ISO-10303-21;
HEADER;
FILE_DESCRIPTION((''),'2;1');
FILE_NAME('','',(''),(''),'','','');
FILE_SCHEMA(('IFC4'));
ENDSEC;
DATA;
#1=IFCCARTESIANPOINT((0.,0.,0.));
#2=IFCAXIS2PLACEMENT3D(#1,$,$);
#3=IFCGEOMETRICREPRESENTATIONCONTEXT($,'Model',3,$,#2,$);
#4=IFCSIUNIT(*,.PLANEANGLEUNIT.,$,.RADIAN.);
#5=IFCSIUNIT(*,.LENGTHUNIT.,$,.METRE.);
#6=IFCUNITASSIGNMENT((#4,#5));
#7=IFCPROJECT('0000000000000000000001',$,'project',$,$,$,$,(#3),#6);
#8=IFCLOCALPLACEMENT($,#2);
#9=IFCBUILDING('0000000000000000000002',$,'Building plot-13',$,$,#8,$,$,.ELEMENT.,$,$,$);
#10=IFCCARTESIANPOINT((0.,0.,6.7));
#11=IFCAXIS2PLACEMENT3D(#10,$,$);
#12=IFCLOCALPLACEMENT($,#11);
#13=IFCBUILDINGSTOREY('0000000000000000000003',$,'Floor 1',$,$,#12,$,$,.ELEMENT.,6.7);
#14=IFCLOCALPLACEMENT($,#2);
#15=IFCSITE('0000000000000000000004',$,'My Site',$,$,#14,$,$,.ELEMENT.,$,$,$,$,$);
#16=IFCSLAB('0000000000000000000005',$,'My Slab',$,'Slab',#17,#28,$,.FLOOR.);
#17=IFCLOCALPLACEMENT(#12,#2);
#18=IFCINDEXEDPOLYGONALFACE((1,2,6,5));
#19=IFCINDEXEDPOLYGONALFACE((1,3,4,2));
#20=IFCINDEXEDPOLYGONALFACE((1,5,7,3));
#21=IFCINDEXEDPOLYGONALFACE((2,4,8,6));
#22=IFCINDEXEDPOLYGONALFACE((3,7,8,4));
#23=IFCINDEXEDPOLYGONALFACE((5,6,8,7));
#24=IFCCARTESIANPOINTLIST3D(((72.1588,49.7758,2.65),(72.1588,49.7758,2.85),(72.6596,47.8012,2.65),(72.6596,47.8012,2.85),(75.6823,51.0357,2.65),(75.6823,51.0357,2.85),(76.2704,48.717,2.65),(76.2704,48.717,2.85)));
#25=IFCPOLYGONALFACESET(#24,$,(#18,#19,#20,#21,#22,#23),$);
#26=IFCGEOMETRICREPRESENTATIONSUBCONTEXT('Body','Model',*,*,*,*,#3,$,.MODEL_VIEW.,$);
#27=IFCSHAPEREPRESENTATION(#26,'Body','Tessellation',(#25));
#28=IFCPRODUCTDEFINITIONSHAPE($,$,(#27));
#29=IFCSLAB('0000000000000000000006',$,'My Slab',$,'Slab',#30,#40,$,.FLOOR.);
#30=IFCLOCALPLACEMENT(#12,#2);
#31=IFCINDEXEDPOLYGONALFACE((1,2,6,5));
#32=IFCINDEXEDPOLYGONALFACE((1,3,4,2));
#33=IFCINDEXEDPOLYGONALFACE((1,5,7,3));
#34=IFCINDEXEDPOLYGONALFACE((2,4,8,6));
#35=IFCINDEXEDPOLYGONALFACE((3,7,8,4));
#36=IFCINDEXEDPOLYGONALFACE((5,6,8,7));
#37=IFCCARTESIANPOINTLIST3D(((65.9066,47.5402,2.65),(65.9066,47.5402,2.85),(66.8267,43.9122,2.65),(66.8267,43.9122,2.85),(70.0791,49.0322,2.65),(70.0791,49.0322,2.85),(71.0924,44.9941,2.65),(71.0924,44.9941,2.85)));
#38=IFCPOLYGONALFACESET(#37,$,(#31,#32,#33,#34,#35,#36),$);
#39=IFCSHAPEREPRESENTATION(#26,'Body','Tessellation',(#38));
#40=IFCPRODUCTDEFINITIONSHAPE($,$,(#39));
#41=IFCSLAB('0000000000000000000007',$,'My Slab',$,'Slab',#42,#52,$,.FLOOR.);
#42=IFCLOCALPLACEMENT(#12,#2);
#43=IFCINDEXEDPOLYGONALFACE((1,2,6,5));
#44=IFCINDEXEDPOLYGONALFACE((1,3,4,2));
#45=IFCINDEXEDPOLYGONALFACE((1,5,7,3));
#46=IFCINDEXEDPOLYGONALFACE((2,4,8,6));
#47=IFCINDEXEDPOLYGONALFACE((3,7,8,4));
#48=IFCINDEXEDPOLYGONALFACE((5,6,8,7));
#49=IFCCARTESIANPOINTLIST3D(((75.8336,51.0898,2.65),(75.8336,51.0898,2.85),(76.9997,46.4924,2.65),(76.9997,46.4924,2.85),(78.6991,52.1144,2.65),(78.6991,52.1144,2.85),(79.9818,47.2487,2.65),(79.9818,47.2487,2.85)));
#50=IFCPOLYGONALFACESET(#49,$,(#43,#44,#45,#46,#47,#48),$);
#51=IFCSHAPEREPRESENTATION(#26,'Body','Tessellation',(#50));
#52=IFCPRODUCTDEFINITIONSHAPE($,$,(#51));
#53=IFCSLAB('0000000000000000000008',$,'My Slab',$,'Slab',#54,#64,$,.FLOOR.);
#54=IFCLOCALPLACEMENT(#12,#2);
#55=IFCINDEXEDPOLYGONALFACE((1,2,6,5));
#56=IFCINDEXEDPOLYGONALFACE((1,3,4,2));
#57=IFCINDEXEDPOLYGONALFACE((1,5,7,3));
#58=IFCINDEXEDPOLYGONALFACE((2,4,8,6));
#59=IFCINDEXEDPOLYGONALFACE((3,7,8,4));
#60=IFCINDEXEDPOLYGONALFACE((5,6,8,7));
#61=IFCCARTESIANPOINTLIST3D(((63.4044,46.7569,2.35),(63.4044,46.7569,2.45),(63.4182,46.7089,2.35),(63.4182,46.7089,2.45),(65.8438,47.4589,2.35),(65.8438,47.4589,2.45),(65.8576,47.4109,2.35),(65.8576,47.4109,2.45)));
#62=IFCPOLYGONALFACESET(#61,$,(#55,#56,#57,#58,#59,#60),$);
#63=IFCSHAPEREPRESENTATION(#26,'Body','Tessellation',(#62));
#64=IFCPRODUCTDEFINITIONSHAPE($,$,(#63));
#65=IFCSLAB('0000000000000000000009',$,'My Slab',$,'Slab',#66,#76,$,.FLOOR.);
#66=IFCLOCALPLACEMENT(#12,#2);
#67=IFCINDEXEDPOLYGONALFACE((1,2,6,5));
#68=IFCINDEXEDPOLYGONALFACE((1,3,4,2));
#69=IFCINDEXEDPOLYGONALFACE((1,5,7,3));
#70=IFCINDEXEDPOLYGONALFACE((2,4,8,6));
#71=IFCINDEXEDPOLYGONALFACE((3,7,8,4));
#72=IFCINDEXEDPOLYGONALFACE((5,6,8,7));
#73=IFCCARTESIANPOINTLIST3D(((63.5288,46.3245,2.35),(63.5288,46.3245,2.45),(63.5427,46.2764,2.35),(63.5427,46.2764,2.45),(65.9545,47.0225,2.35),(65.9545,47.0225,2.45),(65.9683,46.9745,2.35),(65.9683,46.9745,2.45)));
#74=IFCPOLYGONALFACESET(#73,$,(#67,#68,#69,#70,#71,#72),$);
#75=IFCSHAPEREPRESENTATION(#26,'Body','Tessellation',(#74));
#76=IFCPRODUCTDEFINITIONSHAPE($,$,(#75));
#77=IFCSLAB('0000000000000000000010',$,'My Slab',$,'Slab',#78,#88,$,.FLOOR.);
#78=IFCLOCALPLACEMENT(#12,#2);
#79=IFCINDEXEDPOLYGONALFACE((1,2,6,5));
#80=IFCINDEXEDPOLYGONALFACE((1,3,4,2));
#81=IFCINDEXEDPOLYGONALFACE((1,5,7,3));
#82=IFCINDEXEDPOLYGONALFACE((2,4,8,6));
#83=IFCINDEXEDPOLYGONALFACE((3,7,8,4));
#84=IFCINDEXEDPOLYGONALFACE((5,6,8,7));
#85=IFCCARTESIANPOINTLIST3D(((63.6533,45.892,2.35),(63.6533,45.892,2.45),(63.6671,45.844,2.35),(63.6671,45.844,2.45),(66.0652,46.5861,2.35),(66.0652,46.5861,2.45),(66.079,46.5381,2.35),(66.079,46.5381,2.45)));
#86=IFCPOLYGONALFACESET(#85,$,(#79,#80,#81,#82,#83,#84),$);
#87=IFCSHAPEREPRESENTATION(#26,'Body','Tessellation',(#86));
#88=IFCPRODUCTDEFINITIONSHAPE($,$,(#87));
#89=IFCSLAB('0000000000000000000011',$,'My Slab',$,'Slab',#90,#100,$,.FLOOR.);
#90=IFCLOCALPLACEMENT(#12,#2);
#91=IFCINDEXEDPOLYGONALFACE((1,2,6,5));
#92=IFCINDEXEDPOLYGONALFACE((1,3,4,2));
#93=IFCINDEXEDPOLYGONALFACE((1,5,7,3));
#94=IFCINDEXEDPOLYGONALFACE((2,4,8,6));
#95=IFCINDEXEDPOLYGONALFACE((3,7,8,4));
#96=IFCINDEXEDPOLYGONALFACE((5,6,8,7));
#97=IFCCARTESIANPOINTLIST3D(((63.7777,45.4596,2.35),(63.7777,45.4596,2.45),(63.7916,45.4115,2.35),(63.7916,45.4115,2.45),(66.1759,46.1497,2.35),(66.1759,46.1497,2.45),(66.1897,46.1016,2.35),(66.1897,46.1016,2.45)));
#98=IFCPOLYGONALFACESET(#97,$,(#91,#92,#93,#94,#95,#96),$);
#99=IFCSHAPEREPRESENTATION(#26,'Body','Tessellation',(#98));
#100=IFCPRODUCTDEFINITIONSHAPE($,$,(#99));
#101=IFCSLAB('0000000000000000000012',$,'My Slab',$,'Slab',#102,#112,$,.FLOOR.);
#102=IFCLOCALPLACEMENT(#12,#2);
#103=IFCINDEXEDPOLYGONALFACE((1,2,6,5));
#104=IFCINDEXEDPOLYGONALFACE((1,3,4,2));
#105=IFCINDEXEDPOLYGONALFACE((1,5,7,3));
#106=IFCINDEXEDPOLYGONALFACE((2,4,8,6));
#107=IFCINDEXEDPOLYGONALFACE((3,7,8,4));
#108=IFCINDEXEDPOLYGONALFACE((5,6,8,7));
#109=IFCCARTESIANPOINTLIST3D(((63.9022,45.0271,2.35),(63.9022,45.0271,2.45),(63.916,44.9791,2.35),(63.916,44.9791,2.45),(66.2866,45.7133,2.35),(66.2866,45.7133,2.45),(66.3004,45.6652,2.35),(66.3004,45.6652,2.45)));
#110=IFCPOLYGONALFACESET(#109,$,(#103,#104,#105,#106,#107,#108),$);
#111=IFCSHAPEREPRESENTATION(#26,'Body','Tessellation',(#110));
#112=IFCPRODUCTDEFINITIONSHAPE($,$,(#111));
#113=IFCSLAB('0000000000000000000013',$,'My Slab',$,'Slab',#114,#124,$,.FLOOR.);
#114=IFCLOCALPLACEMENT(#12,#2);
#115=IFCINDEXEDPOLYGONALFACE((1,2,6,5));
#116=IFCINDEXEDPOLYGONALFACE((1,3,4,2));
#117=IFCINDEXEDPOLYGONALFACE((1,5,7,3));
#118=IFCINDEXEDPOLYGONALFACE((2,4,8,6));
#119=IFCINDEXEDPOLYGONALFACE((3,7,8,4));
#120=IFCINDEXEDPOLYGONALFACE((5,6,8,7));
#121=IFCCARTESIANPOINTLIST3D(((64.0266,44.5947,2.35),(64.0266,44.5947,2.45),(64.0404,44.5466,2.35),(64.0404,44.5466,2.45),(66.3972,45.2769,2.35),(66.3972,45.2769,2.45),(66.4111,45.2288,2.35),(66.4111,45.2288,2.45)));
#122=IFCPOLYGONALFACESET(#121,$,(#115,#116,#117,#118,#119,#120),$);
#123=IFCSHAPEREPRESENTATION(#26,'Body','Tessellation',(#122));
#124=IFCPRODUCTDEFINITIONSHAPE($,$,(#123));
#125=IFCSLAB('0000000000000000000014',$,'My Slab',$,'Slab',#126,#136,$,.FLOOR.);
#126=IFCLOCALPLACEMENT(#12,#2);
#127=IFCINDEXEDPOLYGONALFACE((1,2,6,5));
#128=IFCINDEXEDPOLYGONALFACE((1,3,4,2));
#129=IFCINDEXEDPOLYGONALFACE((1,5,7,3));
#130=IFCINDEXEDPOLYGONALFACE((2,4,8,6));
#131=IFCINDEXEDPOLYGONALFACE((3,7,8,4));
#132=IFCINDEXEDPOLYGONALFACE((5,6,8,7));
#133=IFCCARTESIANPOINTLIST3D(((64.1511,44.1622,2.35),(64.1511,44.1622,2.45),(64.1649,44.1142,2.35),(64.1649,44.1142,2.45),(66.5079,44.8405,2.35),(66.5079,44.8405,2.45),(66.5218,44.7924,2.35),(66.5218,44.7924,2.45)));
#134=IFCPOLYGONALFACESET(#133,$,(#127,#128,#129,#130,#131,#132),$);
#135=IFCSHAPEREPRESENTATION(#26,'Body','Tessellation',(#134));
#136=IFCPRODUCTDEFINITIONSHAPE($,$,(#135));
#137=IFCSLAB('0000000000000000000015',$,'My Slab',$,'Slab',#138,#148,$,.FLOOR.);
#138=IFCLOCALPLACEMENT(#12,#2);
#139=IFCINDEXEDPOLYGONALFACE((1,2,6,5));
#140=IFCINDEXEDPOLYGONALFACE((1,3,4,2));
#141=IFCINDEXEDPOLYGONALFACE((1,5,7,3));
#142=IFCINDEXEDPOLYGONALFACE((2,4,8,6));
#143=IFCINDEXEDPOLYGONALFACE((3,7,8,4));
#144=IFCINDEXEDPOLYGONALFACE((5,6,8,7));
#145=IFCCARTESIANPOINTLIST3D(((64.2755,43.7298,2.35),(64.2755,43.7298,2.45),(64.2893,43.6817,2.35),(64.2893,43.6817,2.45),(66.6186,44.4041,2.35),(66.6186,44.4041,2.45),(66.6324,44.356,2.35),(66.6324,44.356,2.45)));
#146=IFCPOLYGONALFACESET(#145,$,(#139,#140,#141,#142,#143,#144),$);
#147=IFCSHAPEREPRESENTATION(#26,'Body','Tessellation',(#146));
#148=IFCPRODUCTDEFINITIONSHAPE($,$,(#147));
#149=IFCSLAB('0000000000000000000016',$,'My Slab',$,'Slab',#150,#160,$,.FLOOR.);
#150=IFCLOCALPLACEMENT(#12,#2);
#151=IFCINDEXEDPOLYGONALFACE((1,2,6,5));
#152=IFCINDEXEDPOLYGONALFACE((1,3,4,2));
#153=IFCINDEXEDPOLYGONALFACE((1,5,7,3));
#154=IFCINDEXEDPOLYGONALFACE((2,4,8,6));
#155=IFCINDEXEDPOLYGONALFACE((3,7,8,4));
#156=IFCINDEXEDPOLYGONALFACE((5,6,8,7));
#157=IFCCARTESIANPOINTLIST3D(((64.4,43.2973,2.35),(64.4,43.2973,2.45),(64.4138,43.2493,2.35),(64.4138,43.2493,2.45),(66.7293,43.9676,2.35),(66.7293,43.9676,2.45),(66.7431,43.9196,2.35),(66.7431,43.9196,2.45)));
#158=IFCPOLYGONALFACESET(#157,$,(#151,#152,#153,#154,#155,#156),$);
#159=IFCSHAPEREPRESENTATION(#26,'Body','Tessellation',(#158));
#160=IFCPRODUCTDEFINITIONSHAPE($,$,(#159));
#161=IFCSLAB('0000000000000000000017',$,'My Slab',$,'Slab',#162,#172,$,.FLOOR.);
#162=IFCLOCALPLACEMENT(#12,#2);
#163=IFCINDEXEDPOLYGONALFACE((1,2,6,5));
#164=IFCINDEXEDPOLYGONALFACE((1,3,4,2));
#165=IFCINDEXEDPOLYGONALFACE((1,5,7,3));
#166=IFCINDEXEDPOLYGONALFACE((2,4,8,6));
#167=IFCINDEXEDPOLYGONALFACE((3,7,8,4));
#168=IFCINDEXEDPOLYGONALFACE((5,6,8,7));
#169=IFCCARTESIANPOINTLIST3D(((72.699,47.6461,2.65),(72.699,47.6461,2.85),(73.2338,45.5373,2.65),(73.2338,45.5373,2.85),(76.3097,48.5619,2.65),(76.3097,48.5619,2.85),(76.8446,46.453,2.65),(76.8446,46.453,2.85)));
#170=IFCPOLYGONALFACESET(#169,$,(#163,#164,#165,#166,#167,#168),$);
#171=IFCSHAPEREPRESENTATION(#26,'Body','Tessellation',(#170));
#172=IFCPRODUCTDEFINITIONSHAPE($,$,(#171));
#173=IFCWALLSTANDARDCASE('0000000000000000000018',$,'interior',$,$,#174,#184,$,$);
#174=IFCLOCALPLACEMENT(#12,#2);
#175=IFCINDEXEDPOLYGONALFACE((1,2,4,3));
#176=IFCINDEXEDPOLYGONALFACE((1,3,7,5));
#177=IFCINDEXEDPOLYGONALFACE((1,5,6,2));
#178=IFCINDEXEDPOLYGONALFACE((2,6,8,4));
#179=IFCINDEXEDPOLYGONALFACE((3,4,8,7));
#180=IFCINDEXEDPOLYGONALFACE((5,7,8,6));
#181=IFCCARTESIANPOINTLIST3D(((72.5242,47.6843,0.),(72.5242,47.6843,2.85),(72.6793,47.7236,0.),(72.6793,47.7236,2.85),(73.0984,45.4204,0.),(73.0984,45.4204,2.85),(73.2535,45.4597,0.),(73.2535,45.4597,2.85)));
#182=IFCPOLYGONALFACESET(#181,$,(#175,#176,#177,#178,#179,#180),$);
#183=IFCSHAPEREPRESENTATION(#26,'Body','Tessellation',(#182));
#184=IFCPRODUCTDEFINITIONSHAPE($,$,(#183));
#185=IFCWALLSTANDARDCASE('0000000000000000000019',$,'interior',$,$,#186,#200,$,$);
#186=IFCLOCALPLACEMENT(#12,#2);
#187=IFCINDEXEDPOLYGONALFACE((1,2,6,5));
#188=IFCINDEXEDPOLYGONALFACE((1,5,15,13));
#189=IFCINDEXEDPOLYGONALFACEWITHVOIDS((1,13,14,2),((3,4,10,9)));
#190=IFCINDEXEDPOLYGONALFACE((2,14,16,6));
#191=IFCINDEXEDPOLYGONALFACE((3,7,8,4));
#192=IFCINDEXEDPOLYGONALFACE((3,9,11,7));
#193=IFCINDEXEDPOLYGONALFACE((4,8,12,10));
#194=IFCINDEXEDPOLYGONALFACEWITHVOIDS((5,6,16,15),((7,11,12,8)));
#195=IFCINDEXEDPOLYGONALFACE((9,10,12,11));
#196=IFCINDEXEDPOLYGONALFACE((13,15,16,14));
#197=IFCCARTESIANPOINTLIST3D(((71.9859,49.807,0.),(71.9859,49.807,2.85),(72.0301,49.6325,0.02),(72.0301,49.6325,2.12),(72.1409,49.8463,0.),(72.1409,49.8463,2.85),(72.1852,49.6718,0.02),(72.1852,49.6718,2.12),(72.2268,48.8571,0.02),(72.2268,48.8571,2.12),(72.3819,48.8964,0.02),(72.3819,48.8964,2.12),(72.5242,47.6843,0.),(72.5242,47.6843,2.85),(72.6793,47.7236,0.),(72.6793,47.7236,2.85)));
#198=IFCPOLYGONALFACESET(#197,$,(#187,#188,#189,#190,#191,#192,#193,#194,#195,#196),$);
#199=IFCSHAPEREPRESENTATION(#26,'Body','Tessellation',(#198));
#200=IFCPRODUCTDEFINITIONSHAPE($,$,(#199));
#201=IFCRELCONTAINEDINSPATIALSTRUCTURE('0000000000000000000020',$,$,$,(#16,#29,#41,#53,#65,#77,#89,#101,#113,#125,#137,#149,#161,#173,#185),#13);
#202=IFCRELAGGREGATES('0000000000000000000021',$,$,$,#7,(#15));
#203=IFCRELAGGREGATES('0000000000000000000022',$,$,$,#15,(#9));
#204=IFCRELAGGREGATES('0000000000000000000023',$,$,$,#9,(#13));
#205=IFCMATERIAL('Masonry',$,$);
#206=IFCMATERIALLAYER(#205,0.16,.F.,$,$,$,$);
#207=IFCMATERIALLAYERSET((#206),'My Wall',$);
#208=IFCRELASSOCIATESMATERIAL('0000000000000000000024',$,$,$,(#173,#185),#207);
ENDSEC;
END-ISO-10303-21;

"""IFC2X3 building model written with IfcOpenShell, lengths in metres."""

from ifc_helpers import new_model, si_unit, frame, origin, place, context, subcontext, project, spatial, polyline, outline, extrude, material, layer, layer_set, layer_usage, element, save


model = new_model("IFC2X3")

# Units and contexts
model_context = context("Model", 3, world=origin())
body_context = subcontext(model_context, "Body", "Model", "MODEL_VIEW")
ifc_project = project(units=[si_unit("PLANEANGLEUNIT", "RADIAN"), si_unit("LENGTHUNIT", "METRE")], contexts=[model_context])

# Site, building, storey
site_placement = place(None, origin())
site = spatial("IfcSite", under=ifc_project, at=site_placement, Name="My Site", CompositionType="ELEMENT")
building_placement = place(None, origin())
building = spatial("IfcBuilding", under=site, at=building_placement, Name="Building plot-13", CompositionType="ELEMENT")
storey_placement = place(None, frame((0.0, 0.0, 6.7)))
storey = spatial("IfcBuildingStorey", under=building, at=storey_placement, Name="Floor 1", CompositionType="ELEMENT", Elevation=6.7)

# Slabs
slab_1_placement = place(storey_placement, frame((0.0, 0.0, 2.65)))
element("IfcSlab", 1, at=slab_1_placement, inside=storey, Name="My Slab", ObjectType="Slab", PredefinedType="FLOOR", context=body_context, shape_type="SweptSolid", body=[
    extrude(outline(polyline([(72.1588, 49.7758), (72.6596, 47.8012), (76.2704, 48.717), (75.6823, 51.0357), (72.1588, 49.7758)])), origin(), (0.0, 0.0, 1.0), 0.2),
])
slab_2_placement = place(storey_placement, frame((0.0, 0.0, 2.65)))
element("IfcSlab", 2, at=slab_2_placement, inside=storey, Name="My Slab", ObjectType="Slab", PredefinedType="FLOOR", context=body_context, shape_type="SweptSolid", body=[
    extrude(outline(polyline([(66.8267, 43.9122), (71.0924, 44.9941), (70.0791, 49.0322), (65.9066, 47.5402), (66.8267, 43.9122)])), origin(), (0.0, 0.0, 1.0), 0.2),
])
slab_3_placement = place(storey_placement, frame((0.0, 0.0, 2.65)))
element("IfcSlab", 3, at=slab_3_placement, inside=storey, Name="My Slab", ObjectType="Slab", PredefinedType="FLOOR", context=body_context, shape_type="SweptSolid", body=[
    extrude(outline(polyline([(76.9997, 46.4924), (79.9818, 47.2487), (78.6991, 52.1144), (75.8336, 51.0898), (76.9997, 46.4924)])), origin(), (0.0, 0.0, 1.0), 0.2),
])
slab_4_placement = place(storey_placement, frame((0.0, 0.0, 2.35)))
element("IfcSlab", 4, at=slab_4_placement, inside=storey, Name="My Slab", ObjectType="Slab", PredefinedType="FLOOR", context=body_context, shape_type="SweptSolid", body=[
    extrude(outline(polyline([(63.4044, 46.7569), (63.4182, 46.7089), (65.8576, 47.4109), (65.8438, 47.4589), (63.4044, 46.7569)])), origin(), (0.0, 0.0, 1.0), 0.1),
])
slab_5_placement = place(storey_placement, frame((0.0, 0.0, 2.35)))
element("IfcSlab", 5, at=slab_5_placement, inside=storey, Name="My Slab", ObjectType="Slab", PredefinedType="FLOOR", context=body_context, shape_type="SweptSolid", body=[
    extrude(outline(polyline([(63.5288, 46.3245), (63.5427, 46.2764), (65.9683, 46.9745), (65.9545, 47.0225), (63.5288, 46.3245)])), origin(), (0.0, 0.0, 1.0), 0.1),
])
slab_6_placement = place(storey_placement, frame((0.0, 0.0, 2.35)))
element("IfcSlab", 6, at=slab_6_placement, inside=storey, Name="My Slab", ObjectType="Slab", PredefinedType="FLOOR", context=body_context, shape_type="SweptSolid", body=[
    extrude(outline(polyline([(63.6533, 45.892), (63.6671, 45.844), (66.079, 46.5381), (66.0652, 46.5861), (63.6533, 45.892)])), origin(), (0.0, 0.0, 1.0), 0.1),
])
slab_7_placement = place(storey_placement, frame((0.0, 0.0, 2.35)))
element("IfcSlab", 7, at=slab_7_placement, inside=storey, Name="My Slab", ObjectType="Slab", PredefinedType="FLOOR", context=body_context, shape_type="SweptSolid", body=[
    extrude(outline(polyline([(63.7777, 45.4596), (63.7916, 45.4115), (66.1897, 46.1016), (66.1759, 46.1497), (63.7777, 45.4596)])), origin(), (0.0, 0.0, 1.0), 0.1),
])
slab_8_placement = place(storey_placement, frame((0.0, 0.0, 2.35)))
element("IfcSlab", 8, at=slab_8_placement, inside=storey, Name="My Slab", ObjectType="Slab", PredefinedType="FLOOR", context=body_context, shape_type="SweptSolid", body=[
    extrude(outline(polyline([(63.9022, 45.0271), (63.916, 44.9791), (66.3004, 45.6652), (66.2866, 45.7133), (63.9022, 45.0271)])), origin(), (0.0, 0.0, 1.0), 0.1),
])
slab_9_placement = place(storey_placement, frame((0.0, 0.0, 2.35)))
element("IfcSlab", 9, at=slab_9_placement, inside=storey, Name="My Slab", ObjectType="Slab", PredefinedType="FLOOR", context=body_context, shape_type="SweptSolid", body=[
    extrude(outline(polyline([(64.0266, 44.5947), (64.0404, 44.5466), (66.4111, 45.2288), (66.3972, 45.2769), (64.0266, 44.5947)])), origin(), (0.0, 0.0, 1.0), 0.1),
])
slab_10_placement = place(storey_placement, frame((0.0, 0.0, 2.35)))
element("IfcSlab", 10, at=slab_10_placement, inside=storey, Name="My Slab", ObjectType="Slab", PredefinedType="FLOOR", context=body_context, shape_type="SweptSolid", body=[
    extrude(outline(polyline([(64.1511, 44.1622), (64.1649, 44.1142), (66.5218, 44.7924), (66.5079, 44.8405), (64.1511, 44.1622)])), origin(), (0.0, 0.0, 1.0), 0.1),
])
slab_11_placement = place(storey_placement, frame((0.0, 0.0, 2.35)))
element("IfcSlab", 11, at=slab_11_placement, inside=storey, Name="My Slab", ObjectType="Slab", PredefinedType="FLOOR", context=body_context, shape_type="SweptSolid", body=[
    extrude(outline(polyline([(64.2755, 43.7298), (64.2893, 43.6817), (66.6324, 44.356), (66.6186, 44.4041), (64.2755, 43.7298)])), origin(), (0.0, 0.0, 1.0), 0.1),
])
slab_12_placement = place(storey_placement, frame((0.0, 0.0, 2.35)))
element("IfcSlab", 12, at=slab_12_placement, inside=storey, Name="My Slab", ObjectType="Slab", PredefinedType="FLOOR", context=body_context, shape_type="SweptSolid", body=[
    extrude(outline(polyline([(64.4, 43.2973), (64.4138, 43.2493), (66.7431, 43.9196), (66.7293, 43.9676), (64.4, 43.2973)])), origin(), (0.0, 0.0, 1.0), 0.1),
])
slab_13_placement = place(storey_placement, frame((0.0, 0.0, 2.65)))
element("IfcSlab", 13, at=slab_13_placement, inside=storey, Name="My Slab", ObjectType="Slab", PredefinedType="FLOOR", context=body_context, shape_type="SweptSolid", body=[
    extrude(outline(polyline([(72.699, 47.6461), (73.2338, 45.5373), (76.8446, 46.453), (76.3097, 48.5619), (72.699, 47.6461)])), origin(), (0.0, 0.0, 1.0), 0.2),
])

# Wall
ifc_material = material(Name="Masonry")
ifc_layer = layer(ifc_material, 0.16, ventilated=False)
ifc_layer_set = layer_set([ifc_layer], Name="My Wall")
ifc_layer_usage = layer_usage(ifc_layer_set, "AXIS2", "NEGATIVE", 0.08)
wall_1_placement = place(storey_placement, origin())
element("IfcWallStandardCase", 14, at=wall_1_placement, inside=storey, material=ifc_layer_usage, Name="interior", context=body_context, shape_type="SweptSolid", body=[
    extrude(outline(polyline([(72.6793, 47.7236), (72.5242, 47.6843), (73.0984, 45.4204), (73.2535, 45.4597), (72.6793, 47.7236)])), origin(), (0.0, 0.0, 1.0), 2.85),
])

# Wall, opening
wall_2_placement = place(storey_placement, origin())
wall_2 = element("IfcWallStandardCase", 15, at=wall_2_placement, inside=storey, material=ifc_layer_usage, Name="interior", context=body_context, shape_type="SweptSolid", body=[
    extrude(outline(polyline([(72.1409, 49.8463), (71.9859, 49.807), (72.5242, 47.6843), (72.6793, 47.7236), (72.1409, 49.8463)])), origin(), (0.0, 0.0, 1.0), 2.85),
])
opening_1_placement = place(storey_placement, frame((0.0, 0.0, 0.02)))
element("IfcOpeningElement", 16, at=opening_1_placement, cuts=wall_2, ObjectType="Opening", context=body_context, shape_type="SweptSolid", body=[
    extrude(outline(polyline([(72.0301, 49.6325), (72.2268, 48.8571), (72.3819, 48.8964), (72.1852, 49.6718), (72.0301, 49.6325)])), origin(), (0.0, 0.0, 1.0), 2.1),
])

save(model, "model.ifc")
